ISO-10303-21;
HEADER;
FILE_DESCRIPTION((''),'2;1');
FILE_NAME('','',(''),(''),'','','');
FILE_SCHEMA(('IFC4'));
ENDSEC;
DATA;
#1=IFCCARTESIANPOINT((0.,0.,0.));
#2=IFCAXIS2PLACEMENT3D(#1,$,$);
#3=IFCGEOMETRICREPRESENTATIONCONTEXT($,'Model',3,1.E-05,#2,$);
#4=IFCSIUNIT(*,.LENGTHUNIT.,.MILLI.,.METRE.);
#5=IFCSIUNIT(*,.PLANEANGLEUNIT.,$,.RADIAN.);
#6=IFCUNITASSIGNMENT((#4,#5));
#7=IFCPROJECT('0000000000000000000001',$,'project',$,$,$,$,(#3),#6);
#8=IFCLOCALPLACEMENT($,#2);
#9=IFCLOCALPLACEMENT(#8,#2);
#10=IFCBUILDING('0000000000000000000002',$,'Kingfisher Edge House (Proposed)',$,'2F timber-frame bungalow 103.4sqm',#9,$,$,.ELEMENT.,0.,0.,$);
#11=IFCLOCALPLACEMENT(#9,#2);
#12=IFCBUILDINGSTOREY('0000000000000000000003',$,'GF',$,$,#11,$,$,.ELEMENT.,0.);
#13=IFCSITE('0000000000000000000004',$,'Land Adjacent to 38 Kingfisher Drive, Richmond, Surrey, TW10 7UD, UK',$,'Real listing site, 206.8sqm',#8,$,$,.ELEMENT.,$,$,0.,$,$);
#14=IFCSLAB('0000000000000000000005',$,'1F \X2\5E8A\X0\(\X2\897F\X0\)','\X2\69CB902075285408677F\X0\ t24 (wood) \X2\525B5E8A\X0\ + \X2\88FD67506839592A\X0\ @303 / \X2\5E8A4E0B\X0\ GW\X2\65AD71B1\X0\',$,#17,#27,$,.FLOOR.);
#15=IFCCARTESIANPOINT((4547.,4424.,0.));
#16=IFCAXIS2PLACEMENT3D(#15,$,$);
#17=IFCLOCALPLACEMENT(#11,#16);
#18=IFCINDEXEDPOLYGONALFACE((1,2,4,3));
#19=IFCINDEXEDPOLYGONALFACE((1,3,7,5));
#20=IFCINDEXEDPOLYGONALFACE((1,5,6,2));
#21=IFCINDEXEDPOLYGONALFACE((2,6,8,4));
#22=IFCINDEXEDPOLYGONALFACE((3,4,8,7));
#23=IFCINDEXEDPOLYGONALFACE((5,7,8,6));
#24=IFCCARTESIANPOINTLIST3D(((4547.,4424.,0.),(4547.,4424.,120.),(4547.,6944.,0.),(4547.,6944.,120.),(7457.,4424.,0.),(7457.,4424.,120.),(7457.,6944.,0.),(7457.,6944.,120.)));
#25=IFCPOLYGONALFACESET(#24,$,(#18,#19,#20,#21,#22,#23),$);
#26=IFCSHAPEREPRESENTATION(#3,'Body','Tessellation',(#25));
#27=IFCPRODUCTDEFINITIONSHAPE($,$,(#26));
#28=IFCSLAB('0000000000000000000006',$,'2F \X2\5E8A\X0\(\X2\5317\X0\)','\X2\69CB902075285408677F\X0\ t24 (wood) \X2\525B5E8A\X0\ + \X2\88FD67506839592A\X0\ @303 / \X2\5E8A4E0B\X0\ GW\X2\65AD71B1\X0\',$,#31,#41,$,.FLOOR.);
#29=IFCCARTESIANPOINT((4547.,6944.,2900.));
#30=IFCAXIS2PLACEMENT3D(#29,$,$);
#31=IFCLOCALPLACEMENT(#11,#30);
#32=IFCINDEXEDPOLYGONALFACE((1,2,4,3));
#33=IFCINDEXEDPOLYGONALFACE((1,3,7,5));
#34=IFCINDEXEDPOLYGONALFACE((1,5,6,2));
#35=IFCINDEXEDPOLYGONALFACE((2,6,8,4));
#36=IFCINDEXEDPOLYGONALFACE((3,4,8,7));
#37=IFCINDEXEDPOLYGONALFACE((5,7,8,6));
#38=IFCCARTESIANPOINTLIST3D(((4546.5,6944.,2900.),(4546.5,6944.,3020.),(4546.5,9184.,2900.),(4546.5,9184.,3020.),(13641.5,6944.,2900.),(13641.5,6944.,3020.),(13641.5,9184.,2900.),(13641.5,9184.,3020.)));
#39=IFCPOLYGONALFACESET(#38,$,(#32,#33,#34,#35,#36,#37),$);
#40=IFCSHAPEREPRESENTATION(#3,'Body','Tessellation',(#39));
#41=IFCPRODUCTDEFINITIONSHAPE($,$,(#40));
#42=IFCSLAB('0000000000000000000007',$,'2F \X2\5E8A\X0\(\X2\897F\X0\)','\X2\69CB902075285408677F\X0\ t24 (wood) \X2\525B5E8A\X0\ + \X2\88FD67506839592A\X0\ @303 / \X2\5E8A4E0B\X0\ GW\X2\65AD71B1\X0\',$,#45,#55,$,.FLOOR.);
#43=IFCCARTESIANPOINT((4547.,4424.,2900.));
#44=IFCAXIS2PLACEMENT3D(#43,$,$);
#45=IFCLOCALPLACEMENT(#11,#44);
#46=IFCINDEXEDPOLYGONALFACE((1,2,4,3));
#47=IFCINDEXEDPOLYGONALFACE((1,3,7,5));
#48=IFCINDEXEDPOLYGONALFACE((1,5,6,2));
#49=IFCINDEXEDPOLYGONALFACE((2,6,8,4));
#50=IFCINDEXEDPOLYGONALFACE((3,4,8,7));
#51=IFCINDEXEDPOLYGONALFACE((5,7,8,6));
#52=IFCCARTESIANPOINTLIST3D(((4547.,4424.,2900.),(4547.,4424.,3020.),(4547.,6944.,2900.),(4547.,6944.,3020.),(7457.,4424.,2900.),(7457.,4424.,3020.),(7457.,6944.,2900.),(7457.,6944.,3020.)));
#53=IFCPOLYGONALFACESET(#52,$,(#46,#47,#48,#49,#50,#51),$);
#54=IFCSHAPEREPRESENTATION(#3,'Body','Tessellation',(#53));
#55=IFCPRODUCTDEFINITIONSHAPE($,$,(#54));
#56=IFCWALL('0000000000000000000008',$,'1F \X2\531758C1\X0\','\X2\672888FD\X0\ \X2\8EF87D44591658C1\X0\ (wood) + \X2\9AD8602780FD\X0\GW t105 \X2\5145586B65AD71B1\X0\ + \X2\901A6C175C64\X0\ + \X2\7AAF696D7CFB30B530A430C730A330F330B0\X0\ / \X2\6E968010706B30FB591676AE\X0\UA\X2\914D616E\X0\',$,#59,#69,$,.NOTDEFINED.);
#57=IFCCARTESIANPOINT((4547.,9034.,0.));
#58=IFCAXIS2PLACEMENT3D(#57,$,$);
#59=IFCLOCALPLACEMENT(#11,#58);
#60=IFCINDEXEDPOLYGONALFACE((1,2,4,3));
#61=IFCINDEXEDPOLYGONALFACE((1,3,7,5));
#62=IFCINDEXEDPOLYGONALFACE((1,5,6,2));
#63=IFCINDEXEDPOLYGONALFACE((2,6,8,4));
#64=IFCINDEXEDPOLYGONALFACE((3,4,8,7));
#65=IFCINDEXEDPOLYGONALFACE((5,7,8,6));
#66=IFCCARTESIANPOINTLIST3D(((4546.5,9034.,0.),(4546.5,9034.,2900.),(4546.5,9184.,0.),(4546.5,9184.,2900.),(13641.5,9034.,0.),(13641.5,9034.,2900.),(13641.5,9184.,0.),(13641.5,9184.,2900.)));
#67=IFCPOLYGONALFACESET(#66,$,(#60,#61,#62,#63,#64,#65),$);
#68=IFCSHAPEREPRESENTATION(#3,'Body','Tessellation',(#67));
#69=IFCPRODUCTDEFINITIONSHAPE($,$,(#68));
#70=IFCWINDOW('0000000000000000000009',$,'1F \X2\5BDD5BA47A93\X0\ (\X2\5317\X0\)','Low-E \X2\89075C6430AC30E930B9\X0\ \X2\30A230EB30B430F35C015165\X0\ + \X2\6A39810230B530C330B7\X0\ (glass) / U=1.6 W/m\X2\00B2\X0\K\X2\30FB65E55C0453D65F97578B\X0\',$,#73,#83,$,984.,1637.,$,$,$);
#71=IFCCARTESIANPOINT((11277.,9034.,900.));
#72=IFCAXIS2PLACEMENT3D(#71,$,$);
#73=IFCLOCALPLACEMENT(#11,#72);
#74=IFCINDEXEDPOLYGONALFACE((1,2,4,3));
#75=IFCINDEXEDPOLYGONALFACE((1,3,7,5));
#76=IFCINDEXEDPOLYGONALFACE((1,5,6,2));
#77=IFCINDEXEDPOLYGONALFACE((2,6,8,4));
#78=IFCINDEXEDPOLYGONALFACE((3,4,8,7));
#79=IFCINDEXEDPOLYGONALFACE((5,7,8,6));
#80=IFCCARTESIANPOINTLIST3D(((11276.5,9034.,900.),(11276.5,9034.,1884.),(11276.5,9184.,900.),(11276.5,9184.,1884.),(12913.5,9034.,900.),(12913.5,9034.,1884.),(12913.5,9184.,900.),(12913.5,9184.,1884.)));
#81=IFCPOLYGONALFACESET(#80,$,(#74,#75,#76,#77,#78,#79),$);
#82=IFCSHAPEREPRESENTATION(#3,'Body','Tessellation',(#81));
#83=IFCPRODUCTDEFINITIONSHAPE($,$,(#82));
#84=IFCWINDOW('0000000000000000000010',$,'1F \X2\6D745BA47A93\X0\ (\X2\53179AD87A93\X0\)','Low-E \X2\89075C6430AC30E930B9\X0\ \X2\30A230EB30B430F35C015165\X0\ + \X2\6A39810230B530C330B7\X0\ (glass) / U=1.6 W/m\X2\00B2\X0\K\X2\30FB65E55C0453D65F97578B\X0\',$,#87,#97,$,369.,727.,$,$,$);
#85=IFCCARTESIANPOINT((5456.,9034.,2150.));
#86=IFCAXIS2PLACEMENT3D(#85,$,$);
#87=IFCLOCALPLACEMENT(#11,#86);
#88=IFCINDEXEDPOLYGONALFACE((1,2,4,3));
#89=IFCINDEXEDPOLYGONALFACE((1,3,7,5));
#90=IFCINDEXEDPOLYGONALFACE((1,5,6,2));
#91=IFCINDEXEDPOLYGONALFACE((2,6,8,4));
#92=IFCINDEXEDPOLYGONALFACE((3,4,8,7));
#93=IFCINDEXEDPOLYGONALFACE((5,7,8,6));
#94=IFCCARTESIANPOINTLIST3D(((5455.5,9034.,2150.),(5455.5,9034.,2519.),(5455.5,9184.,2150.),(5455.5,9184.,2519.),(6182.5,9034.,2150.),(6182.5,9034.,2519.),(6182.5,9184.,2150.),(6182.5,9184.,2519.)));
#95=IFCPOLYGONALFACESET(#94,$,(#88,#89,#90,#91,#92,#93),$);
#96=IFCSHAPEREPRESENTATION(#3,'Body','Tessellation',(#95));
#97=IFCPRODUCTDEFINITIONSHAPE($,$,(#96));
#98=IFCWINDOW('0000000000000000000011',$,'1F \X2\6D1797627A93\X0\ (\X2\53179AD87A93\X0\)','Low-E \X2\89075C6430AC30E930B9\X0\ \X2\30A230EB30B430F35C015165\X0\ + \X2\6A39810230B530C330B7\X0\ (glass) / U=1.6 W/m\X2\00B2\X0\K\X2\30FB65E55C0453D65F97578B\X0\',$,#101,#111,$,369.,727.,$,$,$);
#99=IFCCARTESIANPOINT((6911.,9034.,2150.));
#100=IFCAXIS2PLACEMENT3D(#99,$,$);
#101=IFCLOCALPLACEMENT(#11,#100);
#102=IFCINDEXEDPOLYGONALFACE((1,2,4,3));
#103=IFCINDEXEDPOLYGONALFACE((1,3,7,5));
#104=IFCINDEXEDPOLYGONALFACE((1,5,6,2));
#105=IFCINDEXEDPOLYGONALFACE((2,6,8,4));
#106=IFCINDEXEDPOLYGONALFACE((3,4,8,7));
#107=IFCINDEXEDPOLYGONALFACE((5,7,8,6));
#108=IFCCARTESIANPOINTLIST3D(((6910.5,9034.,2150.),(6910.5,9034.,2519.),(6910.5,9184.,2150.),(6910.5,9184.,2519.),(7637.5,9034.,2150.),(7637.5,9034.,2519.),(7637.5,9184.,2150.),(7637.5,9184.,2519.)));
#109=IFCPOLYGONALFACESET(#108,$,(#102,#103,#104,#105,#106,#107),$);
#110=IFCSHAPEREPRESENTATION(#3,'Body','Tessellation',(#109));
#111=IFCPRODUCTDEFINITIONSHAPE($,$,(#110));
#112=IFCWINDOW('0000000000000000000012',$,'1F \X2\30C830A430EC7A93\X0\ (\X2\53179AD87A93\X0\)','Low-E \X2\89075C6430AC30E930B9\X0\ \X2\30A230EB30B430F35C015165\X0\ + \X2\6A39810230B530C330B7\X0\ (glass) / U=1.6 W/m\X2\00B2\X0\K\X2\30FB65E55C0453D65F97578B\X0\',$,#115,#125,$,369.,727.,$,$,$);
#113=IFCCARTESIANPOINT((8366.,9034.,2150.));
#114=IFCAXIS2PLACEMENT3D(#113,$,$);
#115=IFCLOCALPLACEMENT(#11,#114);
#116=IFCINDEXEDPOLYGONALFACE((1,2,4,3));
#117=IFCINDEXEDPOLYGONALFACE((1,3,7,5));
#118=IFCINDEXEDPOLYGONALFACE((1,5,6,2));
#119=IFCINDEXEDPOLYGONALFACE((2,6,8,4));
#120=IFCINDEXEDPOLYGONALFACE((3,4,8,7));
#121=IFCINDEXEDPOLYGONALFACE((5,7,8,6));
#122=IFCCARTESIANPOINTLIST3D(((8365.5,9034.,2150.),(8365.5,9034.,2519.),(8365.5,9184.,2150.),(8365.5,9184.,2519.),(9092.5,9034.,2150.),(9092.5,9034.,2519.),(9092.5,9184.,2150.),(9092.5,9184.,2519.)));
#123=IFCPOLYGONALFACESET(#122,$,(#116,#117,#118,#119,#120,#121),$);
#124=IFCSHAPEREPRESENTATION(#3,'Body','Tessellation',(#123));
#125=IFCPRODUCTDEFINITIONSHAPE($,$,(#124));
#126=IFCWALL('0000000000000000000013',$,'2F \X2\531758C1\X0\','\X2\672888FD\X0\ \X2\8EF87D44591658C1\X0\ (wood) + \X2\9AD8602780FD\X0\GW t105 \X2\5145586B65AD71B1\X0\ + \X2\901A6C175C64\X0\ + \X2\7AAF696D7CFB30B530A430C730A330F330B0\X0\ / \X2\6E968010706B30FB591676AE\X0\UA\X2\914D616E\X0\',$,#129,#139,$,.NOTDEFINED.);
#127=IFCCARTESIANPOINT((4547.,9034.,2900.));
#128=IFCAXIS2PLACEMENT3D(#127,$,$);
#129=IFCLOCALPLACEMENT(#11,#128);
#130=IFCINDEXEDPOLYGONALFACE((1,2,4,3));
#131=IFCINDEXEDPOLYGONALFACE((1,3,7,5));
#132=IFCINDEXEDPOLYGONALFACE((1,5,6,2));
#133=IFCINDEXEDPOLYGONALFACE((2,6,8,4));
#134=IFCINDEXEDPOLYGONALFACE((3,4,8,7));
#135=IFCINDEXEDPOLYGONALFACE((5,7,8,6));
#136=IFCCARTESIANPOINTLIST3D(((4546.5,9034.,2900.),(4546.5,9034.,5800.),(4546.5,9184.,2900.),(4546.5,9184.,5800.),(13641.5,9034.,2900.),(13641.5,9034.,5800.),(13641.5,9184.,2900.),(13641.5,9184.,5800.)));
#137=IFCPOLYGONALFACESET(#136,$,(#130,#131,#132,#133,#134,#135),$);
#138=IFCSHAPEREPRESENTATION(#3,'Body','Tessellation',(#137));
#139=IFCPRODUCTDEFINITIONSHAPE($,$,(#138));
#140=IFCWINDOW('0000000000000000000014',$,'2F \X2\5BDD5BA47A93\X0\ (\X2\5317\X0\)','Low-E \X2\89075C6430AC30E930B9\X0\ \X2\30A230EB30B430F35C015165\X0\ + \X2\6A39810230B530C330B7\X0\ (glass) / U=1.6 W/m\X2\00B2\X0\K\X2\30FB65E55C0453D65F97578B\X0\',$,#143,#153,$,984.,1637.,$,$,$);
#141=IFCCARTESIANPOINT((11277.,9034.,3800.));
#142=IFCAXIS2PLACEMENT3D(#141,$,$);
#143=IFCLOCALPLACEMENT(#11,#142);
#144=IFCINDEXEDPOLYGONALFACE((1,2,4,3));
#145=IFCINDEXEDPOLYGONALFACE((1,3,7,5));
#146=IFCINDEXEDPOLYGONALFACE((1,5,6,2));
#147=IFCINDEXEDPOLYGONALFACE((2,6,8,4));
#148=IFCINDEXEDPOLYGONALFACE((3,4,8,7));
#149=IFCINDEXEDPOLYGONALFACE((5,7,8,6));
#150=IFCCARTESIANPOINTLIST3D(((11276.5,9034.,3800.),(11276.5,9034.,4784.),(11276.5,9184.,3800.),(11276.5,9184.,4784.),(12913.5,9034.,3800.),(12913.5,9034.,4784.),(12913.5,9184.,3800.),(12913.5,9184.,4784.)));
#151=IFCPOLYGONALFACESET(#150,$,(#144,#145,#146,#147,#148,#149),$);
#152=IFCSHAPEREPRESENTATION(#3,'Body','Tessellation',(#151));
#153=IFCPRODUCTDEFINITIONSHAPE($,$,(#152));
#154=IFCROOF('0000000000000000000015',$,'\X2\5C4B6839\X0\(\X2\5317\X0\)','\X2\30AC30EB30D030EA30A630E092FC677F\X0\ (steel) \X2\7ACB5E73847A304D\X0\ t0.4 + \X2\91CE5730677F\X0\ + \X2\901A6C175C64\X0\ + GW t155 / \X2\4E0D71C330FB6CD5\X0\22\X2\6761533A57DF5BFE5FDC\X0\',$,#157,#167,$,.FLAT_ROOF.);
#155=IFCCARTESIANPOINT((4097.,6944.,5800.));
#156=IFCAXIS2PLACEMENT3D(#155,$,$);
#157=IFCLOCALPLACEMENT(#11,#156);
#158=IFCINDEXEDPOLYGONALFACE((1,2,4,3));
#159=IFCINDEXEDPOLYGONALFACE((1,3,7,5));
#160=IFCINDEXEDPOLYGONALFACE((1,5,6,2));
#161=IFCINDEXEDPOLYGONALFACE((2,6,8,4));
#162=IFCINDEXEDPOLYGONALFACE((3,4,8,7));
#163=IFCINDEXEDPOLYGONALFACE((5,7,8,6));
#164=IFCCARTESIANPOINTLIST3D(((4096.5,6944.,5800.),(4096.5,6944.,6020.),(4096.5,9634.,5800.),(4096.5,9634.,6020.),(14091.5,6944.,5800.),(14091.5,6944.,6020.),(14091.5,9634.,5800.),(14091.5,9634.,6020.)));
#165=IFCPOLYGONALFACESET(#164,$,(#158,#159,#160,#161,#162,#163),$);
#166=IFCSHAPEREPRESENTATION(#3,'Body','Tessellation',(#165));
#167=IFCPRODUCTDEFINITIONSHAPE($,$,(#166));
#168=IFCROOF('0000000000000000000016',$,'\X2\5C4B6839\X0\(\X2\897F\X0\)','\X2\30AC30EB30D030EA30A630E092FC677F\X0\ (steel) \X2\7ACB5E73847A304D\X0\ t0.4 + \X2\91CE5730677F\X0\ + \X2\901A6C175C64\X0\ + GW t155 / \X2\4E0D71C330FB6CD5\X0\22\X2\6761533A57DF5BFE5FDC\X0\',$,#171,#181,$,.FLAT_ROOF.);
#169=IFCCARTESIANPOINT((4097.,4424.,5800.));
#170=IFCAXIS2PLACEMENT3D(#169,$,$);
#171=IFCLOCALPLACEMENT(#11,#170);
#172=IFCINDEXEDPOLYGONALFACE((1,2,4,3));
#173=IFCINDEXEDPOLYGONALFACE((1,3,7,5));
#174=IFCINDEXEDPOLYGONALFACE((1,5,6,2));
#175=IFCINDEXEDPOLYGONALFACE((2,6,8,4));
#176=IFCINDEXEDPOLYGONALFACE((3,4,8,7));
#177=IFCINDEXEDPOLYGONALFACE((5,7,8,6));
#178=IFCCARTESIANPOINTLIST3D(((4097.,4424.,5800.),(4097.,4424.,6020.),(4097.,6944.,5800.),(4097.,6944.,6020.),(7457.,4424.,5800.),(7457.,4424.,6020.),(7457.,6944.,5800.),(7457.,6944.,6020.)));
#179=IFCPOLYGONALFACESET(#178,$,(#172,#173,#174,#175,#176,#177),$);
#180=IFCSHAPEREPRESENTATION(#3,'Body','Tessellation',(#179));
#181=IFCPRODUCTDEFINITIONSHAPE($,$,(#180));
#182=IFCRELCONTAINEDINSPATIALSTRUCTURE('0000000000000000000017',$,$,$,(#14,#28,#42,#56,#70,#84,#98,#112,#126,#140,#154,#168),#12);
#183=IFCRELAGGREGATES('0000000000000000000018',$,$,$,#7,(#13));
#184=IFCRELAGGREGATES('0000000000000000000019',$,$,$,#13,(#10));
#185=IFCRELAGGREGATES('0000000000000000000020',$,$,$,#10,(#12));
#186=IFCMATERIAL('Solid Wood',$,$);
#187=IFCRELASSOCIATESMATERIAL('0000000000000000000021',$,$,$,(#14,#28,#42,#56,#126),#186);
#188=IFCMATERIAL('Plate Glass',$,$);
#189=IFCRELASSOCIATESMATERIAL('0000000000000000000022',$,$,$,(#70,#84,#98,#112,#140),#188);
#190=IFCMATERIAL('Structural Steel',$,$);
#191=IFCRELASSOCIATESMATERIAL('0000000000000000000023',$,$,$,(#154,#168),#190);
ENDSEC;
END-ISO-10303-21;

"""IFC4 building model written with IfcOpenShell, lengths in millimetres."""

from ifc_helpers import new_model, si_unit, frame, frame_2d, origin, place, context, project, spatial, rectangle, extrude, material, element, fill, save


model = new_model("IFC4")

# Units and contexts
model_context = context("Model", 3, precision=1e-05, world=origin())
ifc_project = project(units=[si_unit("LENGTHUNIT", "METRE", prefix="MILLI"), si_unit("PLANEANGLEUNIT", "RADIAN")], contexts=[model_context])

# Site, building, storey
site_placement = place(None, origin())
site = spatial("IfcSite", under=ifc_project, at=site_placement, Name="Land Adjacent to 38 Kingfisher Drive, Richmond, Surrey, TW10 7UD, UK", ObjectType="Real listing site, 206.8sqm", CompositionType="ELEMENT", RefElevation=0.0)
building_placement = place(site_placement, origin())
building = spatial("IfcBuilding", under=site, at=building_placement, Name="Kingfisher Edge House (Proposed)", ObjectType="2F timber-frame bungalow 103.4sqm", CompositionType="ELEMENT", ElevationOfRefHeight=0.0, ElevationOfTerrain=0.0)
storey_placement = place(building_placement, origin())
storey = spatial("IfcBuildingStorey", under=building, at=storey_placement, Name="GF", CompositionType="ELEMENT", Elevation=0.0)

# Slabs
ifc_material_1 = material(Name="Solid Wood")
slab_1_placement = place(storey_placement, frame((4547.0, 4424.0, 0.0)))
element("IfcSlab", 1, at=slab_1_placement, inside=storey, material=ifc_material_1, Name="1F 床(西)", Description="構造用合板 t24 (wood) 剛床 + 製材根太 @303 / 床下 GW断熱", PredefinedType="FLOOR", context=model_context, shape_type="SweptSolid", body=[
    extrude(rectangle(XDim=2910.0, YDim=2520.0, at=frame_2d((1455.0, 1260.0))), frame((4547.0, 4424.0, 0.0)), (0.0, 0.0, 1.0), 120.0),
])
slab_2_placement = place(storey_placement, frame((4547.0, 6944.0, 2900.0)))
element("IfcSlab", 2, at=slab_2_placement, inside=storey, material=ifc_material_1, Name="2F 床(北)", Description="構造用合板 t24 (wood) 剛床 + 製材根太 @303 / 床下 GW断熱", PredefinedType="FLOOR", context=model_context, shape_type="SweptSolid", body=[
    extrude(rectangle(XDim=9095.0, YDim=2240.0, at=frame_2d((4547.0, 1120.0))), frame((4547.0, 6944.0, 2900.0)), (0.0, 0.0, 1.0), 120.0),
])
slab_3_placement = place(storey_placement, frame((4547.0, 4424.0, 2900.0)))
element("IfcSlab", 3, at=slab_3_placement, inside=storey, material=ifc_material_1, Name="2F 床(西)", Description="構造用合板 t24 (wood) 剛床 + 製材根太 @303 / 床下 GW断熱", PredefinedType="FLOOR", context=model_context, shape_type="SweptSolid", body=[
    extrude(rectangle(XDim=2910.0, YDim=2520.0, at=frame_2d((1455.0, 1260.0))), frame((4547.0, 4424.0, 2900.0)), (0.0, 0.0, 1.0), 120.0),
])

# Wall, openings, windows
wall_1_placement = place(storey_placement, frame((4547.0, 9034.0, 0.0)))
wall_1 = element("IfcWall", 4, at=wall_1_placement, inside=storey, material=ifc_material_1, Name="1F 北壁", Description="木製 軸組外壁 (wood) + 高性能GW t105 充填断熱 + 通気層 + 窯業系サイディング / 準耐火・外皮UA配慮", PredefinedType="NOTDEFINED", context=model_context, shape_type="SweptSolid", body=[
    extrude(rectangle(XDim=9095.0, YDim=150.0, at=frame_2d((4547.0, 75.0))), frame((4547.0, 9034.0, 0.0)), (0.0, 0.0, 1.0), 2900.0),
])
opening_1_placement = place(storey_placement, frame((11277.0, 9034.0, 900.0)))
opening_1 = element("IfcOpeningElement", 5, at=opening_1_placement, cuts=wall_1, PredefinedType="NOTDEFINED", context=model_context, shape_type="SweptSolid", body=[
    extrude(rectangle(XDim=1637.0, YDim=150.0, at=frame_2d((818.0, 75.0))), frame((11277.0, 9034.0, 900.0)), (0.0, 0.0, 1.0), 984.0),
])
opening_2_placement = place(storey_placement, frame((5456.0, 9034.0, 2150.0)))
opening_2 = element("IfcOpeningElement", 6, at=opening_2_placement, cuts=wall_1, PredefinedType="NOTDEFINED", context=model_context, shape_type="SweptSolid", body=[
    extrude(rectangle(XDim=727.0, YDim=150.0, at=frame_2d((363.0, 75.0))), frame((5456.0, 9034.0, 2150.0)), (0.0, 0.0, 1.0), 369.0),
])
opening_3_placement = place(storey_placement, frame((6911.0, 9034.0, 2150.0)))
opening_3 = element("IfcOpeningElement", 7, at=opening_3_placement, cuts=wall_1, PredefinedType="NOTDEFINED", context=model_context, shape_type="SweptSolid", body=[
    extrude(rectangle(XDim=727.0, YDim=150.0, at=frame_2d((363.0, 75.0))), frame((6911.0, 9034.0, 2150.0)), (0.0, 0.0, 1.0), 369.0),
])
opening_4_placement = place(storey_placement, frame((8366.0, 9034.0, 2150.0)))
opening_4 = element("IfcOpeningElement", 8, at=opening_4_placement, cuts=wall_1, PredefinedType="NOTDEFINED", context=model_context, shape_type="SweptSolid", body=[
    extrude(rectangle(XDim=727.0, YDim=150.0, at=frame_2d((363.0, 75.0))), frame((8366.0, 9034.0, 2150.0)), (0.0, 0.0, 1.0), 369.0),
])
ifc_material_2 = material(Name="Plate Glass")
window_1_placement = place(storey_placement, frame((11277.0, 9034.0, 900.0)))
window_1 = element("IfcWindow", 9, at=window_1_placement, inside=storey, material=ifc_material_2, Name="1F 寝室窓 (北)", Description="Low-E 複層ガラス アルゴン封入 + 樹脂サッシ (glass) / U=1.6 W/m²K・日射取得型", OverallHeight=984.0, OverallWidth=1637.0, context=model_context, shape_type="SweptSolid", body=[
    extrude(rectangle(XDim=1637.0, YDim=150.0, at=frame_2d((818.0, 75.0))), frame((11277.0, 9034.0, 900.0)), (0.0, 0.0, 1.0), 984.0),
])
fill(opening_1, window_1)
window_2_placement = place(storey_placement, frame((5456.0, 9034.0, 2150.0)))
window_2 = element("IfcWindow", 10, at=window_2_placement, inside=storey, material=ifc_material_2, Name="1F 浴室窓 (北高窓)", Description="Low-E 複層ガラス アルゴン封入 + 樹脂サッシ (glass) / U=1.6 W/m²K・日射取得型", OverallHeight=369.0, OverallWidth=727.0, context=model_context, shape_type="SweptSolid", body=[
    extrude(rectangle(XDim=727.0, YDim=150.0, at=frame_2d((363.0, 75.0))), frame((5456.0, 9034.0, 2150.0)), (0.0, 0.0, 1.0), 369.0),
])
fill(opening_2, window_2)
window_3_placement = place(storey_placement, frame((6911.0, 9034.0, 2150.0)))
window_3 = element("IfcWindow", 11, at=window_3_placement, inside=storey, material=ifc_material_2, Name="1F 洗面窓 (北高窓)", Description="Low-E 複層ガラス アルゴン封入 + 樹脂サッシ (glass) / U=1.6 W/m²K・日射取得型", OverallHeight=369.0, OverallWidth=727.0, context=model_context, shape_type="SweptSolid", body=[
    extrude(rectangle(XDim=727.0, YDim=150.0, at=frame_2d((363.0, 75.0))), frame((6911.0, 9034.0, 2150.0)), (0.0, 0.0, 1.0), 369.0),
])
fill(opening_3, window_3)
window_4_placement = place(storey_placement, frame((8366.0, 9034.0, 2150.0)))
window_4 = element("IfcWindow", 12, at=window_4_placement, inside=storey, material=ifc_material_2, Name="1F トイレ窓 (北高窓)", Description="Low-E 複層ガラス アルゴン封入 + 樹脂サッシ (glass) / U=1.6 W/m²K・日射取得型", OverallHeight=369.0, OverallWidth=727.0, context=model_context, shape_type="SweptSolid", body=[
    extrude(rectangle(XDim=727.0, YDim=150.0, at=frame_2d((363.0, 75.0))), frame((8366.0, 9034.0, 2150.0)), (0.0, 0.0, 1.0), 369.0),
])
fill(opening_4, window_4)

# Wall, opening, window
wall_2_placement = place(storey_placement, frame((4547.0, 9034.0, 2900.0)))
wall_2 = element("IfcWall", 13, at=wall_2_placement, inside=storey, material=ifc_material_1, Name="2F 北壁", Description="木製 軸組外壁 (wood) + 高性能GW t105 充填断熱 + 通気層 + 窯業系サイディング / 準耐火・外皮UA配慮", PredefinedType="NOTDEFINED", context=model_context, shape_type="SweptSolid", body=[
    extrude(rectangle(XDim=9095.0, YDim=150.0, at=frame_2d((4547.0, 75.0))), frame((4547.0, 9034.0, 2900.0)), (0.0, 0.0, 1.0), 2900.0),
])
opening_5_placement = place(storey_placement, frame((11277.0, 9034.0, 3800.0)))
opening_5 = element("IfcOpeningElement", 14, at=opening_5_placement, cuts=wall_2, PredefinedType="NOTDEFINED", context=model_context, shape_type="SweptSolid", body=[
    extrude(rectangle(XDim=1637.0, YDim=150.0, at=frame_2d((818.0, 75.0))), frame((11277.0, 9034.0, 3800.0)), (0.0, 0.0, 1.0), 984.0),
])
window_5_placement = place(storey_placement, frame((11277.0, 9034.0, 3800.0)))
window_5 = element("IfcWindow", 15, at=window_5_placement, inside=storey, material=ifc_material_2, Name="2F 寝室窓 (北)", Description="Low-E 複層ガラス アルゴン封入 + 樹脂サッシ (glass) / U=1.6 W/m²K・日射取得型", OverallHeight=984.0, OverallWidth=1637.0, context=model_context, shape_type="SweptSolid", body=[
    extrude(rectangle(XDim=1637.0, YDim=150.0, at=frame_2d((818.0, 75.0))), frame((11277.0, 9034.0, 3800.0)), (0.0, 0.0, 1.0), 984.0),
])
fill(opening_5, window_5)

# Roofs
ifc_material_3 = material(Name="Structural Steel")
for number, where, name in (
    (16, (4097.0, 6944.0, 5800.0), "屋根(北)"),
):
    element("IfcRoof", number, at=place(storey_placement, frame(where)), inside=storey, material=ifc_material_3, Name=name, Description="ガルバリウム鋼板 (steel) 立平葺き t0.4 + 野地板 + 通気層 + GW t155 / 不燃・法22条区域対応", PredefinedType="FLAT_ROOF", context=model_context, shape_type="SweptSolid", body=[
        extrude(rectangle(XDim=9995.0, YDim=2690.0, at=frame_2d((4997.0, 1345.0))), frame((4097.0, 6944.0, 5800.0)), (0.0, 0.0, 1.0), 220.0),
    ])
roof_placement = place(storey_placement, frame((4097.0, 4424.0, 5800.0)))
element("IfcRoof", 17, at=roof_placement, inside=storey, material=ifc_material_3, Name="屋根(西)", Description="ガルバリウム鋼板 (steel) 立平葺き t0.4 + 野地板 + 通気層 + GW t155 / 不燃・法22条区域対応", PredefinedType="FLAT_ROOF", context=model_context, shape_type="SweptSolid", body=[
    extrude(rectangle(XDim=3360.0, YDim=2520.0, at=frame_2d((1680.0, 1260.0))), frame((4097.0, 4424.0, 5800.0)), (0.0, 0.0, 1.0), 220.0),
])

save(model, "model.ifc")
